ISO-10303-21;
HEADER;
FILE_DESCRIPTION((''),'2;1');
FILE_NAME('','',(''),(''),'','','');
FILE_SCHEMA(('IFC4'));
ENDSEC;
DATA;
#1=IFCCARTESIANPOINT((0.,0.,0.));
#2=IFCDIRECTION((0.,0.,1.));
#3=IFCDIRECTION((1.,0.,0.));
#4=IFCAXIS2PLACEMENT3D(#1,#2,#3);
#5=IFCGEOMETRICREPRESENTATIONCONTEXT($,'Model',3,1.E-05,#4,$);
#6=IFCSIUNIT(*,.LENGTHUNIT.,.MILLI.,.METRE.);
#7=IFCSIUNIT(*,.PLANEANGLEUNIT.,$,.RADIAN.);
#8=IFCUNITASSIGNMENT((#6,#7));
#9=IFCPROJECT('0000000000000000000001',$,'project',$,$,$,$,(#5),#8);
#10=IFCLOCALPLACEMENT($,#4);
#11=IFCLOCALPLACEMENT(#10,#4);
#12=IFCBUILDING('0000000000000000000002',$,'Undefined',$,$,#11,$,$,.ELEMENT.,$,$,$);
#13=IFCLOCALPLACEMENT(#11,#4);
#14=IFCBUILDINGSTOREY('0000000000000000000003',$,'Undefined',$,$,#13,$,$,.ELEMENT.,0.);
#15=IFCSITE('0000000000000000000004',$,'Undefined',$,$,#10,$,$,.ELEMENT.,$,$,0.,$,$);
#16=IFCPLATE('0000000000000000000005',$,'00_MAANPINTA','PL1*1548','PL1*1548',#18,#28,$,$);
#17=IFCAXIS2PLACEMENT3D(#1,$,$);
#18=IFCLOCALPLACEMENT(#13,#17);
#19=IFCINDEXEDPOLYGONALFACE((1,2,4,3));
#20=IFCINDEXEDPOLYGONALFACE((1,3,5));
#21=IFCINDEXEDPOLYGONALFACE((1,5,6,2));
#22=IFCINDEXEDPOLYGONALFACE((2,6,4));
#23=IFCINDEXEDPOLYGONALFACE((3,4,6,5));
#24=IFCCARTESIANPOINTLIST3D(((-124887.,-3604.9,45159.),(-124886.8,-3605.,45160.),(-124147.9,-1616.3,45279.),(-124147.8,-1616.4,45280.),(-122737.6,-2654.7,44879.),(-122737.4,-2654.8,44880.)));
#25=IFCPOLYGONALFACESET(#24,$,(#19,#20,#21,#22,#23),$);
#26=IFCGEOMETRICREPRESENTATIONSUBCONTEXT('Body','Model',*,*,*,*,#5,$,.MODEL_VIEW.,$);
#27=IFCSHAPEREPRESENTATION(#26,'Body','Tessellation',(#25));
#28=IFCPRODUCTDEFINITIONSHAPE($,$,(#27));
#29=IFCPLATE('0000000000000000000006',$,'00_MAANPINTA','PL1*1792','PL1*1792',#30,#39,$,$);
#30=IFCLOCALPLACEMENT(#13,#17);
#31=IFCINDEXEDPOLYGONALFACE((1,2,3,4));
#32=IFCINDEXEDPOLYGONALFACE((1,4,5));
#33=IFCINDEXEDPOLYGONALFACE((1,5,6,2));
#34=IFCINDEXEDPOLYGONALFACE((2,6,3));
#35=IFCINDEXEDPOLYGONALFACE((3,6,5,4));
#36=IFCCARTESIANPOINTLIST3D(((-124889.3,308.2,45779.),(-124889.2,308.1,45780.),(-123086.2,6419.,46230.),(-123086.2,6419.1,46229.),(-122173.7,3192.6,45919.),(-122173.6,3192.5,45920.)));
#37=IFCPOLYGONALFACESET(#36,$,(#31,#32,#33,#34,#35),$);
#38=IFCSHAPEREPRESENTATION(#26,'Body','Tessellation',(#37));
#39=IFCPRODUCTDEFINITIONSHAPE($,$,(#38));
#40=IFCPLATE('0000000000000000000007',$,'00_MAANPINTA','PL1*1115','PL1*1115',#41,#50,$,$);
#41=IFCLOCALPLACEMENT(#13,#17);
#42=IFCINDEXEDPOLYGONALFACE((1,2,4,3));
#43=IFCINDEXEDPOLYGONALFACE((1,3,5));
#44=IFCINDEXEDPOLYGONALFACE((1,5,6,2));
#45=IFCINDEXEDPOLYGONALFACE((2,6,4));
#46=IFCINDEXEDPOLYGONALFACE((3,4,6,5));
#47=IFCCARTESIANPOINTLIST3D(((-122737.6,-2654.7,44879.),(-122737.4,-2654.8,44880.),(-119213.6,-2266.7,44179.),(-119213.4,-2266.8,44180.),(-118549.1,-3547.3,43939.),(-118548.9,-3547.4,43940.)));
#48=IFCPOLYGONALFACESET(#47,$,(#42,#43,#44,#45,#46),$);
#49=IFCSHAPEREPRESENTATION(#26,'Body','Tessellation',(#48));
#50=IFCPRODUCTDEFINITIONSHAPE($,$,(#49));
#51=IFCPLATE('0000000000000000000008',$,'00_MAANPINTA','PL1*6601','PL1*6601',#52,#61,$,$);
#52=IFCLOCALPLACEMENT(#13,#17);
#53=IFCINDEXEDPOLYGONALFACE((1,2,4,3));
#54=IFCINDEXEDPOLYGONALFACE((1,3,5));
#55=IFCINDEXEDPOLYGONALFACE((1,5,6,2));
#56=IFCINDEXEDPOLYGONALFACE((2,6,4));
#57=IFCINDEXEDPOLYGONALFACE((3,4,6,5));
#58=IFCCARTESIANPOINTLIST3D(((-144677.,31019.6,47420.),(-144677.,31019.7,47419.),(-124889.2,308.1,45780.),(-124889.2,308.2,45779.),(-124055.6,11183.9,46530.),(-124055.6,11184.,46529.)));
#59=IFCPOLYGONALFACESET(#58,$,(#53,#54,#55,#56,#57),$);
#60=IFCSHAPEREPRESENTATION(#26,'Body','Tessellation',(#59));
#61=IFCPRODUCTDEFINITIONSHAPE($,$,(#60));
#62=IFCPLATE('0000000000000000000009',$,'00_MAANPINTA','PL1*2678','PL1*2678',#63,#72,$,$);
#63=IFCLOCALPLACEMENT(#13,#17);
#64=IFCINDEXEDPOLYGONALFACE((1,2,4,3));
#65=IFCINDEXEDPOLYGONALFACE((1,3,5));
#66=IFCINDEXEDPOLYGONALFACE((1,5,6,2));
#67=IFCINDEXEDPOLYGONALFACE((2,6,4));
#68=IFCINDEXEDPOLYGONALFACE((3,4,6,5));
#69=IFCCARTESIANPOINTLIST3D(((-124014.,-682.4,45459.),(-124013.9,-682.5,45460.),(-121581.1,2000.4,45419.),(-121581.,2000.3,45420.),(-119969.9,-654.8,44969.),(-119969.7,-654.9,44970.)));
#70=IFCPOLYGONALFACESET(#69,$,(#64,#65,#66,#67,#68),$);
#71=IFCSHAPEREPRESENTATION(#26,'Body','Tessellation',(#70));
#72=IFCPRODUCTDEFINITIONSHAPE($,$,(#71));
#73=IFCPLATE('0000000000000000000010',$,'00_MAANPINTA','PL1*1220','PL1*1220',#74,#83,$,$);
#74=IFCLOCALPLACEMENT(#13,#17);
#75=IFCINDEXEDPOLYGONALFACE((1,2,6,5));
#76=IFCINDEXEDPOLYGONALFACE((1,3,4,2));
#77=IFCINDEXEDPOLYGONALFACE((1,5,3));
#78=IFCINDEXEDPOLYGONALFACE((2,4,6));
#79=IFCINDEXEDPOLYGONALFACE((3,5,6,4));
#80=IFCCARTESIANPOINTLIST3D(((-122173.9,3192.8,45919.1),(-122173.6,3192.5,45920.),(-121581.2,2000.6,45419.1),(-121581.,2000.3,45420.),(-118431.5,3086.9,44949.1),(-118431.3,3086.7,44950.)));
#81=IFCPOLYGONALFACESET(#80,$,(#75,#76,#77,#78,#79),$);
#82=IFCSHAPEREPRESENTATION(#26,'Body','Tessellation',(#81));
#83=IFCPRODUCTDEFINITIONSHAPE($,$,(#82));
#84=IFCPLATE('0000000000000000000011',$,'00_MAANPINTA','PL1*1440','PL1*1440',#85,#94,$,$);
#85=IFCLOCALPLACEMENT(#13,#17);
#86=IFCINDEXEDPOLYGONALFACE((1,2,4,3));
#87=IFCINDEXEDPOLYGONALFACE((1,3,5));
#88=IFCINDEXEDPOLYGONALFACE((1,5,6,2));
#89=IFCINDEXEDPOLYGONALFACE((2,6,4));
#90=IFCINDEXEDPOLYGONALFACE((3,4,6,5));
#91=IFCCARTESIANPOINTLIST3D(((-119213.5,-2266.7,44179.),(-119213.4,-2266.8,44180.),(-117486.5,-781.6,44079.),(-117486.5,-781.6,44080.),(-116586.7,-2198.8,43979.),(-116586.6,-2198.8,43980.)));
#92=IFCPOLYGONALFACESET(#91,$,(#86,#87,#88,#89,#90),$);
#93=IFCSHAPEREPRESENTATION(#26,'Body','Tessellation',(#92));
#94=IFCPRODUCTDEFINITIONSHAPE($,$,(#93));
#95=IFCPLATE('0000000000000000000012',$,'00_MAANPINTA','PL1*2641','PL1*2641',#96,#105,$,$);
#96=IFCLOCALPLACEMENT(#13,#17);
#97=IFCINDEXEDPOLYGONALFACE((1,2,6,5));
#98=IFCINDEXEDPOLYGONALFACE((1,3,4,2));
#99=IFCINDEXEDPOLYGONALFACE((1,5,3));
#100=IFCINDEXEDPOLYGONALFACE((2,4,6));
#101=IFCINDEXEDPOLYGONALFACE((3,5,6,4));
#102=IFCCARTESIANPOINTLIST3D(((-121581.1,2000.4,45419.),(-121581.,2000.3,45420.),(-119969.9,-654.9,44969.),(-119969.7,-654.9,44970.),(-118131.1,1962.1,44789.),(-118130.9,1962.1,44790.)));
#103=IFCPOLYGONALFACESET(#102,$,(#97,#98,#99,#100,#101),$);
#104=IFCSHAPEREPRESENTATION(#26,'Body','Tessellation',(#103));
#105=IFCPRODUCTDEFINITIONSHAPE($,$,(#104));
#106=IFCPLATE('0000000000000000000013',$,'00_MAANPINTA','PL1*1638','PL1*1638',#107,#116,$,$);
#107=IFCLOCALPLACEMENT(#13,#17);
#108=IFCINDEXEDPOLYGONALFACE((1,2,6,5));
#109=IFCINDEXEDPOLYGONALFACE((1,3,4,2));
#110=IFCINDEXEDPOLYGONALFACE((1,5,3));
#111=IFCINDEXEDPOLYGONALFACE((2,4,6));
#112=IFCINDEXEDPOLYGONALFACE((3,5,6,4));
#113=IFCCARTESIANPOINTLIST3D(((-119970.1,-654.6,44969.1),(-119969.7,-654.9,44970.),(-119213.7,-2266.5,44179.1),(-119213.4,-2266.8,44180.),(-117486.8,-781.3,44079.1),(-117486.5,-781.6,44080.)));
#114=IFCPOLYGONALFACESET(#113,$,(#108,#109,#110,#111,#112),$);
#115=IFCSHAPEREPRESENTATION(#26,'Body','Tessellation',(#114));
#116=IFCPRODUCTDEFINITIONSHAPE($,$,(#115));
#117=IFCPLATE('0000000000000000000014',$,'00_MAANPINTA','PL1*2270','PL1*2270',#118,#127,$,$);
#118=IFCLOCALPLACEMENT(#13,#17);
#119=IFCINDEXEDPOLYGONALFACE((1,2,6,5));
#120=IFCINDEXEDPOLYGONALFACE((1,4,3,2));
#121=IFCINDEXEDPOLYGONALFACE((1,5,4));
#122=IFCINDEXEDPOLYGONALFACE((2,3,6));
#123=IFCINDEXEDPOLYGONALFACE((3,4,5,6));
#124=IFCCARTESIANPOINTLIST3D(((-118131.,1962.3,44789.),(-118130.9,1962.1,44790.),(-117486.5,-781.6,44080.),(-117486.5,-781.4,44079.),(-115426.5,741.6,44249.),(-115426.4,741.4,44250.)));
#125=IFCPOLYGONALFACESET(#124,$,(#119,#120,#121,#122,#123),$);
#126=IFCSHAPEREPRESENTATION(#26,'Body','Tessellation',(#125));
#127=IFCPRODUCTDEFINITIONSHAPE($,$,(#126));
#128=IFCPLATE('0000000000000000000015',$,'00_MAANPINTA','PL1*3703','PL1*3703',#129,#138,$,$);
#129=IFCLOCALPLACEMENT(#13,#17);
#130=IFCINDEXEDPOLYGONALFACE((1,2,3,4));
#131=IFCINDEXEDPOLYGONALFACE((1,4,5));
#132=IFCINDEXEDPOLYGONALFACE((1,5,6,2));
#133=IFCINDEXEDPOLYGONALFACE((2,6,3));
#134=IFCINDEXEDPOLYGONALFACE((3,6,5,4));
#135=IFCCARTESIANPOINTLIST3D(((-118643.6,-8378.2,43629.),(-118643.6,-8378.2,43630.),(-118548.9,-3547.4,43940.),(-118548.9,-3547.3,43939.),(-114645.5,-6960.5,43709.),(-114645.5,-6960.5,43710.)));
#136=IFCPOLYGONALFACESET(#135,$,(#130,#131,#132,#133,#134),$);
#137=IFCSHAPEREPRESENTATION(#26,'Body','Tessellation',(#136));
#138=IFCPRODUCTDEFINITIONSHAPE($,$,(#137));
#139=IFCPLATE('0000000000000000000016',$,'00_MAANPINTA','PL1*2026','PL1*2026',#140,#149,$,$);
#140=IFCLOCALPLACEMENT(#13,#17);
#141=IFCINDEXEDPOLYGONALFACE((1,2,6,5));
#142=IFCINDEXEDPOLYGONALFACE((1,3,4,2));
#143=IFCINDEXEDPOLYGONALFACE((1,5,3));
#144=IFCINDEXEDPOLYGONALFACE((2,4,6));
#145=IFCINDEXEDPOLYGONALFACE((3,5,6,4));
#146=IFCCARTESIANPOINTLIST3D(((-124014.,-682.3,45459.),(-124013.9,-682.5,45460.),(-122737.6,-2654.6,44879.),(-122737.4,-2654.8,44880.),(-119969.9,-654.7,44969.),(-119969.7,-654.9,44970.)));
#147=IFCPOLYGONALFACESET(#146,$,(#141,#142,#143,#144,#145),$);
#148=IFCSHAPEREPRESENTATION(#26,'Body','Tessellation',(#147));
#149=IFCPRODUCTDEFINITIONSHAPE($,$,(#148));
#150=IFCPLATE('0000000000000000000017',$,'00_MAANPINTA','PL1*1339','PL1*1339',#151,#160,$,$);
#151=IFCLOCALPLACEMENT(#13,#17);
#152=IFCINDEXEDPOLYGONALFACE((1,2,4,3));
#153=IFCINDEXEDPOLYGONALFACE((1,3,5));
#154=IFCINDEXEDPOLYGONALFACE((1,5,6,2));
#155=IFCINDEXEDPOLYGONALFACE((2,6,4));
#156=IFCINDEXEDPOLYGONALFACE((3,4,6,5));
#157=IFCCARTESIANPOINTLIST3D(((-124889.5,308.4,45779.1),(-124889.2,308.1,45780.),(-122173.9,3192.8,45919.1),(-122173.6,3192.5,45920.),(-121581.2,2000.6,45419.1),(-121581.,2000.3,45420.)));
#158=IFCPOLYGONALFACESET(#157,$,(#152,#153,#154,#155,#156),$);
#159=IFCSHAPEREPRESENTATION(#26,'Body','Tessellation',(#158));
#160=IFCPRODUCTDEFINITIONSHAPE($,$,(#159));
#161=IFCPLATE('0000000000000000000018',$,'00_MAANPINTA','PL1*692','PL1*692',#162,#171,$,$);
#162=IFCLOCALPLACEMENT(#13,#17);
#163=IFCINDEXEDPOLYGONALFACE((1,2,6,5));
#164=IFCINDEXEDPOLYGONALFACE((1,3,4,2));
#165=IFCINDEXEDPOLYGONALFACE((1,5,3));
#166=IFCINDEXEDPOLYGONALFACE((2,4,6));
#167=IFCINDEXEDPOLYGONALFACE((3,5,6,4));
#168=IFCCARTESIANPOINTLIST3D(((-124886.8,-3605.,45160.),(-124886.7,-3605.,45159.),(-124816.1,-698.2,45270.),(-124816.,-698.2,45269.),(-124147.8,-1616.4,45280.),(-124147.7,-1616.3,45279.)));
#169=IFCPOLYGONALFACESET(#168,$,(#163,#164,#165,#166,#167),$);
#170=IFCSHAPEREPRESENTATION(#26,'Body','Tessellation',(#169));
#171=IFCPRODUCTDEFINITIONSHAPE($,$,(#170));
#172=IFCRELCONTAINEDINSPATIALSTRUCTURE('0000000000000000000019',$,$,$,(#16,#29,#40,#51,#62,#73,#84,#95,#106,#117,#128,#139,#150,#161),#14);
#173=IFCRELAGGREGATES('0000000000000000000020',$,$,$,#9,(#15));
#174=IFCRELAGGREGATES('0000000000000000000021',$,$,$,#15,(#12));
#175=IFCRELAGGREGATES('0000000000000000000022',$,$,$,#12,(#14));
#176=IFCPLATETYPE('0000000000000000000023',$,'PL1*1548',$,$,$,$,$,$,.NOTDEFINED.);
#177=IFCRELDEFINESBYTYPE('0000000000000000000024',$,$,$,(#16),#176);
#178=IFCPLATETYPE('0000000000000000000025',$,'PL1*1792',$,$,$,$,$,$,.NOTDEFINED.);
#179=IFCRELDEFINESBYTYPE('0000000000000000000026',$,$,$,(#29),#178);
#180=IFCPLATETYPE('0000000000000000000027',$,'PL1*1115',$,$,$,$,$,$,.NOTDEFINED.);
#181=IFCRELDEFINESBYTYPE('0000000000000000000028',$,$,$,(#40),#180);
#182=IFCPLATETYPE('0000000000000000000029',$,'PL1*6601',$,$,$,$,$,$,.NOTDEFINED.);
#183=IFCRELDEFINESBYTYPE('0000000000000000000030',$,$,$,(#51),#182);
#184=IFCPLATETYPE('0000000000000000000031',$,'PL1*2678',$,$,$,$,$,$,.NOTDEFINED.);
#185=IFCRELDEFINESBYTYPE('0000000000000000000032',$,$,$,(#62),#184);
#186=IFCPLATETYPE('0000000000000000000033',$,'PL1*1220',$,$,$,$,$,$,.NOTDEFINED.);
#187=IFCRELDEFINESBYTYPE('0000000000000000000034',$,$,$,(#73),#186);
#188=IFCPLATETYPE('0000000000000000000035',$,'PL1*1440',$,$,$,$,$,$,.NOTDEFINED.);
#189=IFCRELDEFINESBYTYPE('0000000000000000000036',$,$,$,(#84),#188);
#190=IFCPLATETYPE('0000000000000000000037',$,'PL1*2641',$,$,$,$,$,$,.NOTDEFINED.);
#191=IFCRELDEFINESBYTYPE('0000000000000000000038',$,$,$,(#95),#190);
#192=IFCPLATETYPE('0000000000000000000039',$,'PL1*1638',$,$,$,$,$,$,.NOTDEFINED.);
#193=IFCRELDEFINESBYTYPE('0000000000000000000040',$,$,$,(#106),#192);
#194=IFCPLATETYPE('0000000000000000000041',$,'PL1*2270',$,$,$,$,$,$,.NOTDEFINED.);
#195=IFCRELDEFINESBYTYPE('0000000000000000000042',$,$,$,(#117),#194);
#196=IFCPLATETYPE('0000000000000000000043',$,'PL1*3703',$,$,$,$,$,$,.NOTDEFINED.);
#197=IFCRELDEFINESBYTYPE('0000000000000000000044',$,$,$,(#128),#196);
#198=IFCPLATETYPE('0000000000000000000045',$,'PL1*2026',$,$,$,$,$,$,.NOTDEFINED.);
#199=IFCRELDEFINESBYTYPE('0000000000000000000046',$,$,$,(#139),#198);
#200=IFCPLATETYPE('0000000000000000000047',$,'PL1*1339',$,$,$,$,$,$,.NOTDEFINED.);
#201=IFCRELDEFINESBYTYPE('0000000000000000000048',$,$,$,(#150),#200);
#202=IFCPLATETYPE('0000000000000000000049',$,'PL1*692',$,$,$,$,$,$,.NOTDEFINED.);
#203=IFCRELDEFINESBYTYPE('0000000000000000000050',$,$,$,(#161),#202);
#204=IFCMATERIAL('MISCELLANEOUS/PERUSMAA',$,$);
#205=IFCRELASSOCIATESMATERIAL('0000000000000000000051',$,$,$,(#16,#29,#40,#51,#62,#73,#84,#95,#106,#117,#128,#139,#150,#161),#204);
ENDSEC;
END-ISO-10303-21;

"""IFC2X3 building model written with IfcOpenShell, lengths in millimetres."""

from ifc_helpers import new_model, si_unit, frame, origin_with_axes, place, context, subcontext, project, spatial, polyline, outline, extrude, material, type_object, element, save


model = new_model("IFC2X3")

# Units and contexts
model_context = context("Model", 3, precision=1e-05, world=origin_with_axes())
body_context = subcontext(model_context, "Body", "Model", "MODEL_VIEW")
ifc_project = project(units=[si_unit("LENGTHUNIT", "METRE", prefix="MILLI"), si_unit("PLANEANGLEUNIT", "RADIAN")], contexts=[model_context])

# Site, building, storey
site_placement = place(None, origin_with_axes())
site = spatial("IfcSite", under=ifc_project, at=site_placement, Name="Undefined", CompositionType="ELEMENT", RefElevation=0.0)
building_placement = place(site_placement, origin_with_axes())
building = spatial("IfcBuilding", under=site, at=building_placement, Name="Undefined", CompositionType="ELEMENT")
storey_placement = place(building_placement, origin_with_axes())
storey = spatial("IfcBuildingStorey", under=building, at=storey_placement, Name="Undefined", CompositionType="ELEMENT", Elevation=0.0)

# Plates
ifc_material = material(Name="MISCELLANEOUS/PERUSMAA")
plate_type_1 = type_object("IfcPlateType", Name="PL1*1548", PredefinedType="NOTDEFINED")
plate_1_placement = place(storey_placement, frame((-122737.5, -2654.7, 44879.5), z_axis=(-0.183087, 0.126866, -0.974876), x_axis=(-0.908183, -0.401504, 0.118312)))
element("IfcPlate", 1, at=plate_1_placement, inside=storey, type_object=plate_type_1, material=ifc_material, Name="00_MAANPINTA", Description="PL1*1548", ObjectType="PL1*1548", context=body_context, shape_type="SweptSolid", body=[
    extrude(outline(polyline([(0.0, 0.0), (2366.6, 0.0), (911.2, 1548.2), (0.0, 0.0)])), frame((0.0, 0.0, -0.5), z_axis=(0.0, 0.0, 1.0), x_axis=(1.0, 0.0, 0.0)), (0.0, 0.0, 1.0), 1.0),
])
plate_type_2 = type_object("IfcPlateType", Name="PL1*1792", PredefinedType="NOTDEFINED")
plate_2_placement = place(storey_placement, frame((-122173.6, 3192.5, 45919.5), z_axis=(-0.038661, 0.084726, -0.995654), x_axis=(-0.685064, -0.727627, -0.035317)))
element("IfcPlate", 2, at=plate_2_placement, inside=storey, type_object=plate_type_2, material=ifc_material, Name="00_MAANPINTA", Description="PL1*1792", ObjectType="PL1*1792", context=body_context, shape_type="SweptSolid", body=[
    extrude(outline(polyline([(0.0, 0.0), (3964.1, 0.0), (-1733.5, 2886.9), (0.0, 0.0)])), frame((0.0, 0.0, -0.5), z_axis=(0.0, 0.0, 1.0), x_axis=(1.0, 0.0, 0.0)), (0.0, 0.0, 1.0), 1.0),
])
plate_type_3 = type_object("IfcPlateType", Name="PL1*1115", PredefinedType="NOTDEFINED")
plate_3_placement = place(storey_placement, frame((-119213.5, -2266.7, 44179.5), z_axis=(-0.202481, 0.077869, -0.976185), x_axis=(0.454365, -0.875573, -0.164087)))
element("IfcPlate", 3, at=plate_3_placement, inside=storey, type_object=plate_type_3, material=ifc_material, Name="00_MAANPINTA", Description="PL1*1115", ObjectType="PL1*1115", context=body_context, shape_type="SweptSolid", body=[
    extrude(outline(polyline([(0.0, 0.0), (1462.6, 0.0), (-1376.3, 3341.4), (0.0, 0.0)])), frame((0.0, 0.0, -0.5), z_axis=(0.0, 0.0, 1.0), x_axis=(1.0, 0.0, 0.0)), (0.0, 0.0, 1.0), 1.0),
])
plate_type_4 = type_object("IfcPlateType", Name="PL1*6601", PredefinedType="NOTDEFINED")
plate_4_placement = place(storey_placement, frame((-124889.2, 308.2, 45779.5), z_axis=(0.021529, 0.067139, -0.997511), x_axis=(-0.541077, 0.839777, 0.044844)))
element("IfcPlate", 4, at=plate_4_placement, inside=storey, type_object=plate_type_4, material=ifc_material, Name="00_MAANPINTA", Description="PL1*6601", ObjectType="PL1*6601", context=body_context, shape_type="SweptSolid", body=[
    extrude(outline(polyline([(0.0, 0.0), (36571.0, 0.0), (8715.8, 6601.1), (0.0, 0.0)])), frame((0.0, 0.0, -0.5), z_axis=(0.0, 0.0, 1.0), x_axis=(1.0, 0.0, 0.0)), (0.0, 0.0, 1.0), 1.0),
])
plate_type_5 = type_object("IfcPlateType", Name="PL1*2678", PredefinedType="NOTDEFINED")
plate_5_placement = place(storey_placement, frame((-121581.0, 2000.4, 45419.5), z_axis=(-0.120379, 0.094433, -0.988226), x_axis=(0.513406, -0.846081, -0.14339)))
element("IfcPlate", 5, at=plate_5_placement, inside=storey, type_object=plate_type_5, material=ifc_material, Name="00_MAANPINTA", Description="PL1*2678", ObjectType="PL1*2678", context=body_context, shape_type="SweptSolid", body=[
    extrude(outline(polyline([(0.0, 0.0), (3138.3, 0.0), (1015.1, 3476.8), (0.0, 0.0)])), frame((0.0, 0.0, -0.5), z_axis=(0.0, 0.0, 1.0), x_axis=(1.0, 0.0, 0.0)), (0.0, 0.0, 1.0), 1.0),
])
plate_type_6 = type_object("IfcPlateType", Name="PL1*1220", PredefinedType="NOTDEFINED")
plate_6_placement = place(storey_placement, frame((-121581.1, 2000.5, 45419.5), z_axis=(-0.233951, 0.274832, -0.932595), x_axis=(-0.416732, 0.838287, 0.351581)))
element("IfcPlate", 6, at=plate_6_placement, inside=storey, type_object=plate_type_6, material=ifc_material, Name="00_MAANPINTA", Description="PL1*1220", ObjectType="PL1*1220", context=body_context, shape_type="SweptSolid", body=[
    extrude(outline(polyline([(0.0, 0.0), (1422.1, 0.0), (-567.2, 3316.6), (0.0, 0.0)])), frame((0.0, 0.0, -0.5), z_axis=(0.0, 0.0, 1.0), x_axis=(1.0, 0.0, 0.0)), (0.0, 0.0, 1.0), 1.0),
])
plate_type_7 = type_object("IfcPlateType", Name="PL1*1440", PredefinedType="NOTDEFINED")
plate_7_placement = place(storey_placement, frame((-117486.5, -781.6, 44079.5), z_axis=(-0.07646, 0.02179, -0.996835), x_axis=(0.535092, -0.842698, -0.059464)))
element("IfcPlate", 7, at=plate_7_placement, inside=storey, type_object=plate_type_7, material=ifc_material, Name="00_MAANPINTA", Description="PL1*1440", ObjectType="PL1*1440", context=body_context, shape_type="SweptSolid", body=[
    extrude(outline(polyline([(0.0, 0.0), (1681.7, 0.0), (321.5, 2257.1), (0.0, 0.0)])), frame((0.0, 0.0, -0.5), z_axis=(0.0, 0.0, 1.0), x_axis=(1.0, 0.0, 0.0)), (0.0, 0.0, 1.0), 1.0),
])
plate_type_8 = type_object("IfcPlateType", Name="PL1*2641", PredefinedType="NOTDEFINED")
plate_8_placement = place(storey_placement, frame((-119969.8, -654.9, 44969.5), z_axis=(-0.178709, 0.058015, -0.98219), x_axis=(-0.513406, 0.846081, 0.14339)))
element("IfcPlate", 8, at=plate_8_placement, inside=storey, type_object=plate_type_8, material=ifc_material, Name="00_MAANPINTA", Description="PL1*2641", ObjectType="PL1*2641", context=body_context, shape_type="SweptSolid", body=[
    extrude(outline(polyline([(0.0, 0.0), (3138.3, 0.0), (1244.3, 2952.0), (0.0, 0.0)])), frame((0.0, 0.0, -0.5), z_axis=(0.0, 0.0, 1.0), x_axis=(1.0, 0.0, 0.0)), (0.0, 0.0, 1.0), 1.0),
])
plate_type_9 = type_object("IfcPlateType", Name="PL1*1638", PredefinedType="NOTDEFINED")
plate_9_placement = place(storey_placement, frame((-119213.6, -2266.6, 44179.5), z_axis=(-0.308546, 0.29797, -0.903335), x_axis=(-0.388283, 0.827492, 0.405576)))
element("IfcPlate", 9, at=plate_9_placement, inside=storey, type_object=plate_type_9, material=ifc_material, Name="00_MAANPINTA", Description="PL1*1638", ObjectType="PL1*1638", context=body_context, shape_type="SweptSolid", body=[
    extrude(outline(polyline([(0.0, 0.0), (1947.8, 0.0), (517.8, 2220.3), (0.0, 0.0)])), frame((0.0, 0.0, -0.5), z_axis=(0.0, 0.0, 1.0), x_axis=(1.0, 0.0, 0.0)), (0.0, 0.0, 1.0), 1.0),
])
plate_type_10 = type_object("IfcPlateType", Name="PL1*2270", PredefinedType="NOTDEFINED")
plate_10_placement = place(storey_placement, frame((-117486.5, -781.5, 44079.5), z_axis=(-0.089833, 0.22968, -0.969112), x_axis=(-0.221727, 0.944014, 0.244285)))
element("IfcPlate", 10, at=plate_10_placement, inside=storey, type_object=plate_type_10, material=ifc_material, Name="00_MAANPINTA", Description="PL1*2270", ObjectType="PL1*2270", context=body_context, shape_type="SweptSolid", body=[
    extrude(outline(polyline([(0.0, 0.0), (2906.4, 0.0), (1022.5, 2355.2), (0.0, 0.0)])), frame((0.0, 0.0, -0.5), z_axis=(0.0, 0.0, 1.0), x_axis=(1.0, 0.0, 0.0)), (0.0, 0.0, 1.0), 1.0),
])
plate_type_11 = type_object("IfcPlateType", Name="PL1*3703", PredefinedType="NOTDEFINED")
plate_11_placement = place(storey_placement, frame((-118548.9, -3547.4, 43939.5), z_axis=(-0.002759, 0.064093, -0.99794), x_axis=(0.752061, -0.657603, -0.044314)))
element("IfcPlate", 11, at=plate_11_placement, inside=storey, type_object=plate_type_11, material=ifc_material, Name="00_MAANPINTA", Description="PL1*3703", ObjectType="PL1*3703", context=body_context, shape_type="SweptSolid", body=[
    extrude(outline(polyline([(0.0, 0.0), (5190.3, 0.0), (3119.2, 3703.0), (0.0, 0.0)])), frame((0.0, 0.0, -0.5), z_axis=(0.0, 0.0, 1.0), x_axis=(1.0, 0.0, 0.0)), (0.0, 0.0, 1.0), 1.0),
])
plate_type_12 = type_object("IfcPlateType", Name="PL1*2026", PredefinedType="NOTDEFINED")
plate_12_placement = place(storey_placement, frame((-122737.5, -2654.7, 44879.5), z_axis=(-0.119042, 0.208433, -0.970765), x_axis=(-0.527503, 0.815041, 0.239684)))
element("IfcPlate", 12, at=plate_12_placement, inside=storey, type_object=plate_type_12, material=ifc_material, Name="00_MAANPINTA", Description="PL1*2026", ObjectType="PL1*2026", context=body_context, shape_type="SweptSolid", body=[
    extrude(outline(polyline([(0.0, 0.0), (2419.9, 0.0), (191.6, 3410.4), (0.0, 0.0)])), frame((0.0, 0.0, -0.5), z_axis=(0.0, 0.0, 1.0), x_axis=(1.0, 0.0, 0.0)), (0.0, 0.0, 1.0), 1.0),
])
plate_type_13 = type_object("IfcPlateType", Name="PL1*1339", PredefinedType="NOTDEFINED")
plate_13_placement = place(storey_placement, frame((-121581.1, 2000.5, 45419.5), z_axis=(-0.240258, 0.271441, -0.931985), x_axis=(-0.886146, -0.453263, 0.096428)))
element("IfcPlate", 13, at=plate_13_placement, inside=storey, type_object=plate_type_13, material=ifc_material, Name="00_MAANPINTA", Description="PL1*1339", ObjectType="PL1*1339", context=body_context, shape_type="SweptSolid", body=[
    extrude(outline(polyline([(0.0, 0.0), (3733.3, 0.0), (33.0, 1421.8), (0.0, 0.0)])), frame((0.0, 0.0, -0.5), z_axis=(0.0, 0.0, 1.0), x_axis=(1.0, 0.0, 0.0)), (0.0, 0.0, 1.0), 1.0),
])
plate_type_14 = type_object("IfcPlateType", Name="PL1*692", PredefinedType="NOTDEFINED")
plate_14_placement = place(storey_placement, frame((-124147.7, -1616.4, 45279.5), z_axis=(0.064609, 0.036167, -0.997255), x_axis=(-0.347789, -0.935871, -0.056473)))
element("IfcPlate", 14, at=plate_14_placement, inside=storey, type_object=plate_type_14, material=ifc_material, Name="00_MAANPINTA", Description="PL1*692", ObjectType="PL1*692", context=body_context, shape_type="SweptSolid", body=[
    extrude(outline(polyline([(0.0, 0.0), (2124.9, 0.0), (-626.3, 947.4), (0.0, 0.0)])), frame((0.0, 0.0, -0.5), z_axis=(0.0, 0.0, 1.0), x_axis=(1.0, 0.0, 0.0)), (0.0, 0.0, 1.0), 1.0),
])

save(model, "model.ifc")
